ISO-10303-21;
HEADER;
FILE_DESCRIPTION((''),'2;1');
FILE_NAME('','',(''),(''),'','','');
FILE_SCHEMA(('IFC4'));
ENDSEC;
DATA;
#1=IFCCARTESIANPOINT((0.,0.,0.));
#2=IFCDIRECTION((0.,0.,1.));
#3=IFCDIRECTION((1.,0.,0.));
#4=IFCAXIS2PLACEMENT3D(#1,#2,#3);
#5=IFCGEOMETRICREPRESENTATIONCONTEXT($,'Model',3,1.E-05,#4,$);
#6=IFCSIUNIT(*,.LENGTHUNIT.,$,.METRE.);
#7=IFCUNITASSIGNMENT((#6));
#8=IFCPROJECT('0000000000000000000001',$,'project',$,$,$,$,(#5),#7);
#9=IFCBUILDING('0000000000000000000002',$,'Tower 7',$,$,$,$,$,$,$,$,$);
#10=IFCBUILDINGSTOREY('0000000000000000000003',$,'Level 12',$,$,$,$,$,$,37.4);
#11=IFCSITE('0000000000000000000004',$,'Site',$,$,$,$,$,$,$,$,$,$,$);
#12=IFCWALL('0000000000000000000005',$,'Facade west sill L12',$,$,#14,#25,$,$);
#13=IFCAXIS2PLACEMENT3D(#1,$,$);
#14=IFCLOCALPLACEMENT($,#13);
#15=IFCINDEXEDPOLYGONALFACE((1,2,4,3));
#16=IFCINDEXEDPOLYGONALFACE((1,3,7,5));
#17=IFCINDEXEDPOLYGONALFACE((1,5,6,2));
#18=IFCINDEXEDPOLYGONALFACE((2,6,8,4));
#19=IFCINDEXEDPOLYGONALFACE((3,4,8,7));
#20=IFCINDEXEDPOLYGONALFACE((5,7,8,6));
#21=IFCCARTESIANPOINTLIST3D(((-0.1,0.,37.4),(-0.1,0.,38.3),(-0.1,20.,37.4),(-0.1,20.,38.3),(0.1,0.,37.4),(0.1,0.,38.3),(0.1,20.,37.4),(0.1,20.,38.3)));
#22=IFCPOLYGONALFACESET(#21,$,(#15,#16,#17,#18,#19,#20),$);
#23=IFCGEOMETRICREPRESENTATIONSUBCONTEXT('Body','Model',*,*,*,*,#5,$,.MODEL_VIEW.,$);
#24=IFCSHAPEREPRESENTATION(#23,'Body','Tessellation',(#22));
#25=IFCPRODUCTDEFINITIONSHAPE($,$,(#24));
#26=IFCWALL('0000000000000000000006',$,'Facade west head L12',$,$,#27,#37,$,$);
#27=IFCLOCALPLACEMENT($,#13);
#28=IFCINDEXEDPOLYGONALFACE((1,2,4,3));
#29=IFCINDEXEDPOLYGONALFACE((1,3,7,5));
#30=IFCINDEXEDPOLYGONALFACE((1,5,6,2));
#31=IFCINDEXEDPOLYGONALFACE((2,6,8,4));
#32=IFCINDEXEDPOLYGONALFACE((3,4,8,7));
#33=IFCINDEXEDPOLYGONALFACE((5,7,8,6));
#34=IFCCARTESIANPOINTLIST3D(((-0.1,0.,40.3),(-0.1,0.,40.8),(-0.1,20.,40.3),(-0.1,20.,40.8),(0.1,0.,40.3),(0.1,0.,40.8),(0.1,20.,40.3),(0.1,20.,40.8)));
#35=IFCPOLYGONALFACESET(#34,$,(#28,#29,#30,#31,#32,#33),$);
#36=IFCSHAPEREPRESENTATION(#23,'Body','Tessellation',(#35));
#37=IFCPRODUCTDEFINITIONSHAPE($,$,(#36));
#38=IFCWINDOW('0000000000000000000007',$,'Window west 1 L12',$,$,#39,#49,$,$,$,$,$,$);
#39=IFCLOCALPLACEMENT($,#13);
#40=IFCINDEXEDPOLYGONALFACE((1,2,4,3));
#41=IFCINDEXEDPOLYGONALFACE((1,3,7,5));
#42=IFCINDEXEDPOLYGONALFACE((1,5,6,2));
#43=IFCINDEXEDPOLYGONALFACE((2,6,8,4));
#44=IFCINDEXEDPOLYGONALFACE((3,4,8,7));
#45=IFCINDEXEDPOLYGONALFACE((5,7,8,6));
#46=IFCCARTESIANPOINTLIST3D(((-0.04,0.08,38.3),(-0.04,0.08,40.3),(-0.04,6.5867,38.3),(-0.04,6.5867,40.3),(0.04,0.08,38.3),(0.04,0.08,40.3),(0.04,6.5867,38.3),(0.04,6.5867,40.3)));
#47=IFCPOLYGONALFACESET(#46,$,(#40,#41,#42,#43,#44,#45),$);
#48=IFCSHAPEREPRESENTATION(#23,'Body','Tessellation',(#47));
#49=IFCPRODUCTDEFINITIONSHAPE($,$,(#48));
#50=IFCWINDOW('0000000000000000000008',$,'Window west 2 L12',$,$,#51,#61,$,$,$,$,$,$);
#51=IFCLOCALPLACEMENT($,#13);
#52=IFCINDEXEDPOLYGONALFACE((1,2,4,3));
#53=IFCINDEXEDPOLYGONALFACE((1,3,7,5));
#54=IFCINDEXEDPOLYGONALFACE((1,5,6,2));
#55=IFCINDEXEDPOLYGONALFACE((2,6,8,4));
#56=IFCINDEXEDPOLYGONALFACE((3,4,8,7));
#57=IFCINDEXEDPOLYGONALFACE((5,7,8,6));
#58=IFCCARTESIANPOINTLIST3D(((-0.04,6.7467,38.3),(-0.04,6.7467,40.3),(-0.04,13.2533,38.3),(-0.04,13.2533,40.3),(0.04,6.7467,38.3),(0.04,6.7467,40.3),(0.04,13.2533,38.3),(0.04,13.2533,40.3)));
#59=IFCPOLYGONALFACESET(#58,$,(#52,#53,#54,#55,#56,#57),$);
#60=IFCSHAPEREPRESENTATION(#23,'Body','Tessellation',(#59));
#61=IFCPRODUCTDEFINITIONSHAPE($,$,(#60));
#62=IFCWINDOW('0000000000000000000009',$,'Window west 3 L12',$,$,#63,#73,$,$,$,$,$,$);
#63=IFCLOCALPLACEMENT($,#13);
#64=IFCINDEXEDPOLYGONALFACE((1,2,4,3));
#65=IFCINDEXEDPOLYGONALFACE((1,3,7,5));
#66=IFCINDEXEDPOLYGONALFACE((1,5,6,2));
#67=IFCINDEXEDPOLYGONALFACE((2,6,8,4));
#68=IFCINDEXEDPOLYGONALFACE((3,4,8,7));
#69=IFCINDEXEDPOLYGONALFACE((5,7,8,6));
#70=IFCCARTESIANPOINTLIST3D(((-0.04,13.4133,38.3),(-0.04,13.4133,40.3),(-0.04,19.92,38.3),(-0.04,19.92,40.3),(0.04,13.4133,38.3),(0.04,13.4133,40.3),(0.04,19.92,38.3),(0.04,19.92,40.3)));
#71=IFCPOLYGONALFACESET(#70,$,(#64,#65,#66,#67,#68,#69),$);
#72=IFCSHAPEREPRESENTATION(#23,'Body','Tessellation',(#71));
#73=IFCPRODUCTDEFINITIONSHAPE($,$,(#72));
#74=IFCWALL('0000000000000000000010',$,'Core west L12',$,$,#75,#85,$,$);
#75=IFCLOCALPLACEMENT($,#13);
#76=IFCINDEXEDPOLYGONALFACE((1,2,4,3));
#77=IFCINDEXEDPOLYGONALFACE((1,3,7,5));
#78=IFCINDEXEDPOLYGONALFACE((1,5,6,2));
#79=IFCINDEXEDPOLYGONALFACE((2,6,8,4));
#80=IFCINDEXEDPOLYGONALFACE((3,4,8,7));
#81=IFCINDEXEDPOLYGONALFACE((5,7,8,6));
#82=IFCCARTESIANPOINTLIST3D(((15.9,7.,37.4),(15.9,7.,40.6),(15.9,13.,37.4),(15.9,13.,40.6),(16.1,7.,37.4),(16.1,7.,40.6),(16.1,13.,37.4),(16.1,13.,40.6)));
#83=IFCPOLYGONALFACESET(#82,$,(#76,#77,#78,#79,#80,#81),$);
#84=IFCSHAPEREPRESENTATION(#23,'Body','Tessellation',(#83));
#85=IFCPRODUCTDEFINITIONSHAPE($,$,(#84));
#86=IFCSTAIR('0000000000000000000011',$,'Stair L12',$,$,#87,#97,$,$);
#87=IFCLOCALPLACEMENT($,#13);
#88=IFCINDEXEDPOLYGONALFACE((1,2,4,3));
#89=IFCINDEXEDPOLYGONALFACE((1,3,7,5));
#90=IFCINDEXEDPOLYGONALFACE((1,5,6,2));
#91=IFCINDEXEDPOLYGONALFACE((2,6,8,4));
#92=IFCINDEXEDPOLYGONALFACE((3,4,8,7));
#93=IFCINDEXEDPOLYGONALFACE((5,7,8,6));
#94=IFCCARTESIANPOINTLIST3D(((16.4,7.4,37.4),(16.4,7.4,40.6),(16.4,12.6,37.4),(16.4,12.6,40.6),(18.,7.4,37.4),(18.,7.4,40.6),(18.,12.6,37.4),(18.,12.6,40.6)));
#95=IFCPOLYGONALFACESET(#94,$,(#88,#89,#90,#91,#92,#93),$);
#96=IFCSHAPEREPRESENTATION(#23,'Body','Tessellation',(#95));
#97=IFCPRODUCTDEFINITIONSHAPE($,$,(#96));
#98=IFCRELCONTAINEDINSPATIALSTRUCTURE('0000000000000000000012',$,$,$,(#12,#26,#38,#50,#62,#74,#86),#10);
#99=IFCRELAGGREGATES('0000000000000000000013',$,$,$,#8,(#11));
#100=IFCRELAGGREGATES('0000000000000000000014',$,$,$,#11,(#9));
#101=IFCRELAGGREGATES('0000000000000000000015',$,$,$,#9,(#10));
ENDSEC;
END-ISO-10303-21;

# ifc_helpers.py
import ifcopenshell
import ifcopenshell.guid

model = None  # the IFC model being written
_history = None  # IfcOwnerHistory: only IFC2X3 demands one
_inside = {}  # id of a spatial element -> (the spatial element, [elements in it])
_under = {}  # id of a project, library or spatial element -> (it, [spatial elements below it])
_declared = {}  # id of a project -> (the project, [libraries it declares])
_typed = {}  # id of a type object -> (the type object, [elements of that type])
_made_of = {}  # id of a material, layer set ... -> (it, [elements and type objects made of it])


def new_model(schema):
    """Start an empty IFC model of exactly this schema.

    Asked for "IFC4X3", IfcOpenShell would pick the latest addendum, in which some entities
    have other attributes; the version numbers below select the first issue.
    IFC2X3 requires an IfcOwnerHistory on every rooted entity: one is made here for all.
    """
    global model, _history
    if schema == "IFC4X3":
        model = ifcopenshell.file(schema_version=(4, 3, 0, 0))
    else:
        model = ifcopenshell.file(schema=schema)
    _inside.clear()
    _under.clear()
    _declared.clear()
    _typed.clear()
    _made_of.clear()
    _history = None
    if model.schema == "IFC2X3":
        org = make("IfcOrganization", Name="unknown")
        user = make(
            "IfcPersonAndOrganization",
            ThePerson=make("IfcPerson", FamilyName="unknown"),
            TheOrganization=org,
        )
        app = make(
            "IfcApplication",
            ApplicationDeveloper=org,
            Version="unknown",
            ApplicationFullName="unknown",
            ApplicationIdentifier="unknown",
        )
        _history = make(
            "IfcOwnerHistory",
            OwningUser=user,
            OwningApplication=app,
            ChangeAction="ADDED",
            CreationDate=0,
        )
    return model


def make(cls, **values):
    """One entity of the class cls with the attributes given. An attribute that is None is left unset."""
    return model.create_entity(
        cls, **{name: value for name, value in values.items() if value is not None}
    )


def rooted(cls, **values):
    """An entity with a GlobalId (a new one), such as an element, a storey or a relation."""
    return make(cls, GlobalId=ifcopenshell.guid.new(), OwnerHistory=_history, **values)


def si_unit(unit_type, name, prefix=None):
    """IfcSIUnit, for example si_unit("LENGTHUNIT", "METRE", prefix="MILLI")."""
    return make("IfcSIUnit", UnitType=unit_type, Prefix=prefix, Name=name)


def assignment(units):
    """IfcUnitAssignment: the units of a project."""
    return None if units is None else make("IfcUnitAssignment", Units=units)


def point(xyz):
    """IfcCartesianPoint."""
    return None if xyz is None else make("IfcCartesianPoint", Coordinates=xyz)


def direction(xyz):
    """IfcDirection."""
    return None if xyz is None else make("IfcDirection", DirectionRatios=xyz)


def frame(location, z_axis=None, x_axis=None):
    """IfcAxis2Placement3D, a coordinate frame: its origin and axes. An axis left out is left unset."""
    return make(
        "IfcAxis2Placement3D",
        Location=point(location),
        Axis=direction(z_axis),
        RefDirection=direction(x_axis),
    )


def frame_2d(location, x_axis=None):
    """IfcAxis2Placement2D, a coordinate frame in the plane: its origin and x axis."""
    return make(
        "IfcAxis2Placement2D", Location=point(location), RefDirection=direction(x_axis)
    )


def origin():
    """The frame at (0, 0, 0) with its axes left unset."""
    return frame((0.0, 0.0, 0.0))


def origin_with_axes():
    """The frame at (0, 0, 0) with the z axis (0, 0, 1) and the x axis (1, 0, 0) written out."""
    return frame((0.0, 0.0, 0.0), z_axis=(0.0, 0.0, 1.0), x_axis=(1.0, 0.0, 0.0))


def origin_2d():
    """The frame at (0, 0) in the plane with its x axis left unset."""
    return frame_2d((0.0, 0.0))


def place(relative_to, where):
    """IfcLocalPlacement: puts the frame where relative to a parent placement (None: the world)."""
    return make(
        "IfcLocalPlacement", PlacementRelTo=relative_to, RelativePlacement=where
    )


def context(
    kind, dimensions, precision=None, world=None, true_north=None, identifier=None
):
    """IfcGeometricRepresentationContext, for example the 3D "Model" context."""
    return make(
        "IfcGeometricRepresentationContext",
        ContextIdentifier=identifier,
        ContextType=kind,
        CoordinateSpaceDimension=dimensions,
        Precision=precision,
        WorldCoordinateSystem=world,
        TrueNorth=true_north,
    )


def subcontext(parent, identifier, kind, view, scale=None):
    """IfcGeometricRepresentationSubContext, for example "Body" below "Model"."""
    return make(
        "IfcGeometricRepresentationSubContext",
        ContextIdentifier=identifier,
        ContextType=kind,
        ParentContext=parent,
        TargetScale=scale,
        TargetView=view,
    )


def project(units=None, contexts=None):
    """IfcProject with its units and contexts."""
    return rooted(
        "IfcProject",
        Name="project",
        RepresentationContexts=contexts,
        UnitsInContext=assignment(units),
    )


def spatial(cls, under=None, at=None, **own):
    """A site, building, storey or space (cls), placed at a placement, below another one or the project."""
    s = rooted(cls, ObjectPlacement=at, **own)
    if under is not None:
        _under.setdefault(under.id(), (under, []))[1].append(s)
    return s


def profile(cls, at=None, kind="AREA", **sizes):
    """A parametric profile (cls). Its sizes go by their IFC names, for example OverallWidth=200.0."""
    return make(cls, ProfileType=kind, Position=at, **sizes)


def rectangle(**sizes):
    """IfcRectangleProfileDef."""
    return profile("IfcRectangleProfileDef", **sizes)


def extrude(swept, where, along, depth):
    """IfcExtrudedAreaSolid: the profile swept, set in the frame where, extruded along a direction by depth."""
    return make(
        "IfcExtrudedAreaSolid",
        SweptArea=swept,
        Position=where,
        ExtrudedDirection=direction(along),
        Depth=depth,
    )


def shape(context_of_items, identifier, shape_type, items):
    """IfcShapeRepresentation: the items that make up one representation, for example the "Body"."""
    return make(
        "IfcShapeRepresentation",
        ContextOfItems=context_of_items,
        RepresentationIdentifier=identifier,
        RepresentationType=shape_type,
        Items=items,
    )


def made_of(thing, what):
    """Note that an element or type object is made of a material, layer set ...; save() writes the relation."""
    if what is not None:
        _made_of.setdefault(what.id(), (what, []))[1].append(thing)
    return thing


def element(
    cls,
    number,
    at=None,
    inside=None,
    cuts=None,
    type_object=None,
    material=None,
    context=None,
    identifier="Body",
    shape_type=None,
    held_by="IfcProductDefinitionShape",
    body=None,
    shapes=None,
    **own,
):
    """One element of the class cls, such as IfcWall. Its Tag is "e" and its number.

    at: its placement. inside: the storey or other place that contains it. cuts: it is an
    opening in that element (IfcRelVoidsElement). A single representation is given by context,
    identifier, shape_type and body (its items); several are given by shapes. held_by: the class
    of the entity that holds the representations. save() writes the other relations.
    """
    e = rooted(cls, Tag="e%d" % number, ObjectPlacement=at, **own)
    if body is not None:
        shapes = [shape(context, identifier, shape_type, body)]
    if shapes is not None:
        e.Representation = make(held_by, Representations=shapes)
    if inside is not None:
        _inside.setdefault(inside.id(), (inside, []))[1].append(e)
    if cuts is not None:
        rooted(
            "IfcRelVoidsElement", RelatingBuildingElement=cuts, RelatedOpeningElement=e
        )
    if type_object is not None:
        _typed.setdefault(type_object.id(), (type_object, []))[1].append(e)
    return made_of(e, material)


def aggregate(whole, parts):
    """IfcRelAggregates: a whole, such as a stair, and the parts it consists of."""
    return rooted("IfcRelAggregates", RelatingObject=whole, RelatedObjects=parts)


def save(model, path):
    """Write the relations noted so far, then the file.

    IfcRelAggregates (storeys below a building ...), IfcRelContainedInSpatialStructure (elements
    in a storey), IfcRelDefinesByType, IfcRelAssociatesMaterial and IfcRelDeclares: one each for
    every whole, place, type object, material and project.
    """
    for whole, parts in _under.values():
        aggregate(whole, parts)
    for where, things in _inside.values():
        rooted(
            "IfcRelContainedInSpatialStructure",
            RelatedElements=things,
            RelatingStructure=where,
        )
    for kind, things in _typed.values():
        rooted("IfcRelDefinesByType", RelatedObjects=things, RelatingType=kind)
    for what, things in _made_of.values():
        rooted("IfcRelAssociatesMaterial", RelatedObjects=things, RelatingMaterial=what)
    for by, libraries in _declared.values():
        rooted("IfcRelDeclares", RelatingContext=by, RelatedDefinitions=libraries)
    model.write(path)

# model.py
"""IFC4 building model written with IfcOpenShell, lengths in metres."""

from ifc_helpers import new_model, si_unit, frame, origin, origin_with_axes, origin_2d, place, context, subcontext, project, spatial, rectangle, extrude, element, save


model = new_model("IFC4")

# Units and contexts
model_context = context("Model", 3, precision=1e-05, world=origin_with_axes())
body_context = subcontext(model_context, "Body", "Model", "MODEL_VIEW")
ifc_project = project(units=[si_unit("LENGTHUNIT", "METRE")], contexts=[model_context])

# Site, building, storey
site = spatial("IfcSite", under=ifc_project, Name="Site")
building = spatial("IfcBuilding", under=site, Name="Tower 7")
storey = spatial("IfcBuildingStorey", under=building, Name="Level 12", Elevation=37.4)

# Walls
wall_1_placement = place(None, frame((0.0, 10.0, 37.4), z_axis=(0.0, 0.0, 1.0), x_axis=(1.0, 0.0, 0.0)))
element("IfcWall", 1, at=wall_1_placement, inside=storey, Name="Facade west sill L12", context=body_context, shape_type="SweptSolid", body=[
    extrude(rectangle(XDim=0.2, YDim=20.0, at=origin_2d()), origin(), (0.0, 0.0, 1.0), 0.9),
])
wall_2_placement = place(None, frame((0.0, 10.0, 40.3), z_axis=(0.0, 0.0, 1.0), x_axis=(1.0, 0.0, 0.0)))
element("IfcWall", 2, at=wall_2_placement, inside=storey, Name="Facade west head L12", context=body_context, shape_type="SweptSolid", body=[
    extrude(rectangle(XDim=0.2, YDim=20.0, at=origin_2d()), origin(), (0.0, 0.0, 1.0), 0.5),
])

# Windows
for number, where, z_axis, x_axis, name in (
    (3, (0.0, 3.3333, 38.3), (0.0, 0.0, 1.0), (1.0, 0.0, 0.0), "Window west 1 L12"),
    (4, (0.0, 10.0, 38.3), (0.0, 0.0, 1.0), (1.0, 0.0, 0.0), "Window west 2 L12"),
):
    element("IfcWindow", number, at=place(None, frame(where, z_axis=z_axis, x_axis=x_axis)), inside=storey, Name=name, context=body_context, shape_type="SweptSolid", body=[
        extrude(rectangle(XDim=0.08, YDim=6.5067, at=origin_2d()), origin(), (0.0, 0.0, 1.0), 2.0),
    ])
window_1_placement = place(None, frame((0.0, 16.6667, 38.3), z_axis=(0.0, 0.0, 1.0), x_axis=(1.0, 0.0, 0.0)))
element("IfcWindow", 5, at=window_1_placement, inside=storey, Name="Window west 3 L12", context=body_context, shape_type="SweptSolid", body=[
    extrude(rectangle(XDim=0.08, YDim=6.5067, at=origin_2d()), origin(), (0.0, 0.0, 1.0), 2.0),
])

# Wall
wall_3_placement = place(None, frame((16.0, 10.0, 37.4), z_axis=(0.0, 0.0, 1.0), x_axis=(1.0, 0.0, 0.0)))
element("IfcWall", 6, at=wall_3_placement, inside=storey, Name="Core west L12", context=body_context, shape_type="SweptSolid", body=[
    extrude(rectangle(XDim=0.2, YDim=6.0, at=origin_2d()), origin(), (0.0, 0.0, 1.0), 3.2),
])

# Stair
stair_placement = place(None, frame((17.2, 10.0, 37.4), z_axis=(0.0, 0.0, 1.0), x_axis=(1.0, 0.0, 0.0)))
element("IfcStair", 7, at=stair_placement, inside=storey, Name="Stair L12", context=body_context, shape_type="SweptSolid", body=[
    extrude(rectangle(XDim=1.6, YDim=5.2, at=origin_2d()), origin(), (0.0, 0.0, 1.0), 3.2),
])

save(model, "model.ifc")
